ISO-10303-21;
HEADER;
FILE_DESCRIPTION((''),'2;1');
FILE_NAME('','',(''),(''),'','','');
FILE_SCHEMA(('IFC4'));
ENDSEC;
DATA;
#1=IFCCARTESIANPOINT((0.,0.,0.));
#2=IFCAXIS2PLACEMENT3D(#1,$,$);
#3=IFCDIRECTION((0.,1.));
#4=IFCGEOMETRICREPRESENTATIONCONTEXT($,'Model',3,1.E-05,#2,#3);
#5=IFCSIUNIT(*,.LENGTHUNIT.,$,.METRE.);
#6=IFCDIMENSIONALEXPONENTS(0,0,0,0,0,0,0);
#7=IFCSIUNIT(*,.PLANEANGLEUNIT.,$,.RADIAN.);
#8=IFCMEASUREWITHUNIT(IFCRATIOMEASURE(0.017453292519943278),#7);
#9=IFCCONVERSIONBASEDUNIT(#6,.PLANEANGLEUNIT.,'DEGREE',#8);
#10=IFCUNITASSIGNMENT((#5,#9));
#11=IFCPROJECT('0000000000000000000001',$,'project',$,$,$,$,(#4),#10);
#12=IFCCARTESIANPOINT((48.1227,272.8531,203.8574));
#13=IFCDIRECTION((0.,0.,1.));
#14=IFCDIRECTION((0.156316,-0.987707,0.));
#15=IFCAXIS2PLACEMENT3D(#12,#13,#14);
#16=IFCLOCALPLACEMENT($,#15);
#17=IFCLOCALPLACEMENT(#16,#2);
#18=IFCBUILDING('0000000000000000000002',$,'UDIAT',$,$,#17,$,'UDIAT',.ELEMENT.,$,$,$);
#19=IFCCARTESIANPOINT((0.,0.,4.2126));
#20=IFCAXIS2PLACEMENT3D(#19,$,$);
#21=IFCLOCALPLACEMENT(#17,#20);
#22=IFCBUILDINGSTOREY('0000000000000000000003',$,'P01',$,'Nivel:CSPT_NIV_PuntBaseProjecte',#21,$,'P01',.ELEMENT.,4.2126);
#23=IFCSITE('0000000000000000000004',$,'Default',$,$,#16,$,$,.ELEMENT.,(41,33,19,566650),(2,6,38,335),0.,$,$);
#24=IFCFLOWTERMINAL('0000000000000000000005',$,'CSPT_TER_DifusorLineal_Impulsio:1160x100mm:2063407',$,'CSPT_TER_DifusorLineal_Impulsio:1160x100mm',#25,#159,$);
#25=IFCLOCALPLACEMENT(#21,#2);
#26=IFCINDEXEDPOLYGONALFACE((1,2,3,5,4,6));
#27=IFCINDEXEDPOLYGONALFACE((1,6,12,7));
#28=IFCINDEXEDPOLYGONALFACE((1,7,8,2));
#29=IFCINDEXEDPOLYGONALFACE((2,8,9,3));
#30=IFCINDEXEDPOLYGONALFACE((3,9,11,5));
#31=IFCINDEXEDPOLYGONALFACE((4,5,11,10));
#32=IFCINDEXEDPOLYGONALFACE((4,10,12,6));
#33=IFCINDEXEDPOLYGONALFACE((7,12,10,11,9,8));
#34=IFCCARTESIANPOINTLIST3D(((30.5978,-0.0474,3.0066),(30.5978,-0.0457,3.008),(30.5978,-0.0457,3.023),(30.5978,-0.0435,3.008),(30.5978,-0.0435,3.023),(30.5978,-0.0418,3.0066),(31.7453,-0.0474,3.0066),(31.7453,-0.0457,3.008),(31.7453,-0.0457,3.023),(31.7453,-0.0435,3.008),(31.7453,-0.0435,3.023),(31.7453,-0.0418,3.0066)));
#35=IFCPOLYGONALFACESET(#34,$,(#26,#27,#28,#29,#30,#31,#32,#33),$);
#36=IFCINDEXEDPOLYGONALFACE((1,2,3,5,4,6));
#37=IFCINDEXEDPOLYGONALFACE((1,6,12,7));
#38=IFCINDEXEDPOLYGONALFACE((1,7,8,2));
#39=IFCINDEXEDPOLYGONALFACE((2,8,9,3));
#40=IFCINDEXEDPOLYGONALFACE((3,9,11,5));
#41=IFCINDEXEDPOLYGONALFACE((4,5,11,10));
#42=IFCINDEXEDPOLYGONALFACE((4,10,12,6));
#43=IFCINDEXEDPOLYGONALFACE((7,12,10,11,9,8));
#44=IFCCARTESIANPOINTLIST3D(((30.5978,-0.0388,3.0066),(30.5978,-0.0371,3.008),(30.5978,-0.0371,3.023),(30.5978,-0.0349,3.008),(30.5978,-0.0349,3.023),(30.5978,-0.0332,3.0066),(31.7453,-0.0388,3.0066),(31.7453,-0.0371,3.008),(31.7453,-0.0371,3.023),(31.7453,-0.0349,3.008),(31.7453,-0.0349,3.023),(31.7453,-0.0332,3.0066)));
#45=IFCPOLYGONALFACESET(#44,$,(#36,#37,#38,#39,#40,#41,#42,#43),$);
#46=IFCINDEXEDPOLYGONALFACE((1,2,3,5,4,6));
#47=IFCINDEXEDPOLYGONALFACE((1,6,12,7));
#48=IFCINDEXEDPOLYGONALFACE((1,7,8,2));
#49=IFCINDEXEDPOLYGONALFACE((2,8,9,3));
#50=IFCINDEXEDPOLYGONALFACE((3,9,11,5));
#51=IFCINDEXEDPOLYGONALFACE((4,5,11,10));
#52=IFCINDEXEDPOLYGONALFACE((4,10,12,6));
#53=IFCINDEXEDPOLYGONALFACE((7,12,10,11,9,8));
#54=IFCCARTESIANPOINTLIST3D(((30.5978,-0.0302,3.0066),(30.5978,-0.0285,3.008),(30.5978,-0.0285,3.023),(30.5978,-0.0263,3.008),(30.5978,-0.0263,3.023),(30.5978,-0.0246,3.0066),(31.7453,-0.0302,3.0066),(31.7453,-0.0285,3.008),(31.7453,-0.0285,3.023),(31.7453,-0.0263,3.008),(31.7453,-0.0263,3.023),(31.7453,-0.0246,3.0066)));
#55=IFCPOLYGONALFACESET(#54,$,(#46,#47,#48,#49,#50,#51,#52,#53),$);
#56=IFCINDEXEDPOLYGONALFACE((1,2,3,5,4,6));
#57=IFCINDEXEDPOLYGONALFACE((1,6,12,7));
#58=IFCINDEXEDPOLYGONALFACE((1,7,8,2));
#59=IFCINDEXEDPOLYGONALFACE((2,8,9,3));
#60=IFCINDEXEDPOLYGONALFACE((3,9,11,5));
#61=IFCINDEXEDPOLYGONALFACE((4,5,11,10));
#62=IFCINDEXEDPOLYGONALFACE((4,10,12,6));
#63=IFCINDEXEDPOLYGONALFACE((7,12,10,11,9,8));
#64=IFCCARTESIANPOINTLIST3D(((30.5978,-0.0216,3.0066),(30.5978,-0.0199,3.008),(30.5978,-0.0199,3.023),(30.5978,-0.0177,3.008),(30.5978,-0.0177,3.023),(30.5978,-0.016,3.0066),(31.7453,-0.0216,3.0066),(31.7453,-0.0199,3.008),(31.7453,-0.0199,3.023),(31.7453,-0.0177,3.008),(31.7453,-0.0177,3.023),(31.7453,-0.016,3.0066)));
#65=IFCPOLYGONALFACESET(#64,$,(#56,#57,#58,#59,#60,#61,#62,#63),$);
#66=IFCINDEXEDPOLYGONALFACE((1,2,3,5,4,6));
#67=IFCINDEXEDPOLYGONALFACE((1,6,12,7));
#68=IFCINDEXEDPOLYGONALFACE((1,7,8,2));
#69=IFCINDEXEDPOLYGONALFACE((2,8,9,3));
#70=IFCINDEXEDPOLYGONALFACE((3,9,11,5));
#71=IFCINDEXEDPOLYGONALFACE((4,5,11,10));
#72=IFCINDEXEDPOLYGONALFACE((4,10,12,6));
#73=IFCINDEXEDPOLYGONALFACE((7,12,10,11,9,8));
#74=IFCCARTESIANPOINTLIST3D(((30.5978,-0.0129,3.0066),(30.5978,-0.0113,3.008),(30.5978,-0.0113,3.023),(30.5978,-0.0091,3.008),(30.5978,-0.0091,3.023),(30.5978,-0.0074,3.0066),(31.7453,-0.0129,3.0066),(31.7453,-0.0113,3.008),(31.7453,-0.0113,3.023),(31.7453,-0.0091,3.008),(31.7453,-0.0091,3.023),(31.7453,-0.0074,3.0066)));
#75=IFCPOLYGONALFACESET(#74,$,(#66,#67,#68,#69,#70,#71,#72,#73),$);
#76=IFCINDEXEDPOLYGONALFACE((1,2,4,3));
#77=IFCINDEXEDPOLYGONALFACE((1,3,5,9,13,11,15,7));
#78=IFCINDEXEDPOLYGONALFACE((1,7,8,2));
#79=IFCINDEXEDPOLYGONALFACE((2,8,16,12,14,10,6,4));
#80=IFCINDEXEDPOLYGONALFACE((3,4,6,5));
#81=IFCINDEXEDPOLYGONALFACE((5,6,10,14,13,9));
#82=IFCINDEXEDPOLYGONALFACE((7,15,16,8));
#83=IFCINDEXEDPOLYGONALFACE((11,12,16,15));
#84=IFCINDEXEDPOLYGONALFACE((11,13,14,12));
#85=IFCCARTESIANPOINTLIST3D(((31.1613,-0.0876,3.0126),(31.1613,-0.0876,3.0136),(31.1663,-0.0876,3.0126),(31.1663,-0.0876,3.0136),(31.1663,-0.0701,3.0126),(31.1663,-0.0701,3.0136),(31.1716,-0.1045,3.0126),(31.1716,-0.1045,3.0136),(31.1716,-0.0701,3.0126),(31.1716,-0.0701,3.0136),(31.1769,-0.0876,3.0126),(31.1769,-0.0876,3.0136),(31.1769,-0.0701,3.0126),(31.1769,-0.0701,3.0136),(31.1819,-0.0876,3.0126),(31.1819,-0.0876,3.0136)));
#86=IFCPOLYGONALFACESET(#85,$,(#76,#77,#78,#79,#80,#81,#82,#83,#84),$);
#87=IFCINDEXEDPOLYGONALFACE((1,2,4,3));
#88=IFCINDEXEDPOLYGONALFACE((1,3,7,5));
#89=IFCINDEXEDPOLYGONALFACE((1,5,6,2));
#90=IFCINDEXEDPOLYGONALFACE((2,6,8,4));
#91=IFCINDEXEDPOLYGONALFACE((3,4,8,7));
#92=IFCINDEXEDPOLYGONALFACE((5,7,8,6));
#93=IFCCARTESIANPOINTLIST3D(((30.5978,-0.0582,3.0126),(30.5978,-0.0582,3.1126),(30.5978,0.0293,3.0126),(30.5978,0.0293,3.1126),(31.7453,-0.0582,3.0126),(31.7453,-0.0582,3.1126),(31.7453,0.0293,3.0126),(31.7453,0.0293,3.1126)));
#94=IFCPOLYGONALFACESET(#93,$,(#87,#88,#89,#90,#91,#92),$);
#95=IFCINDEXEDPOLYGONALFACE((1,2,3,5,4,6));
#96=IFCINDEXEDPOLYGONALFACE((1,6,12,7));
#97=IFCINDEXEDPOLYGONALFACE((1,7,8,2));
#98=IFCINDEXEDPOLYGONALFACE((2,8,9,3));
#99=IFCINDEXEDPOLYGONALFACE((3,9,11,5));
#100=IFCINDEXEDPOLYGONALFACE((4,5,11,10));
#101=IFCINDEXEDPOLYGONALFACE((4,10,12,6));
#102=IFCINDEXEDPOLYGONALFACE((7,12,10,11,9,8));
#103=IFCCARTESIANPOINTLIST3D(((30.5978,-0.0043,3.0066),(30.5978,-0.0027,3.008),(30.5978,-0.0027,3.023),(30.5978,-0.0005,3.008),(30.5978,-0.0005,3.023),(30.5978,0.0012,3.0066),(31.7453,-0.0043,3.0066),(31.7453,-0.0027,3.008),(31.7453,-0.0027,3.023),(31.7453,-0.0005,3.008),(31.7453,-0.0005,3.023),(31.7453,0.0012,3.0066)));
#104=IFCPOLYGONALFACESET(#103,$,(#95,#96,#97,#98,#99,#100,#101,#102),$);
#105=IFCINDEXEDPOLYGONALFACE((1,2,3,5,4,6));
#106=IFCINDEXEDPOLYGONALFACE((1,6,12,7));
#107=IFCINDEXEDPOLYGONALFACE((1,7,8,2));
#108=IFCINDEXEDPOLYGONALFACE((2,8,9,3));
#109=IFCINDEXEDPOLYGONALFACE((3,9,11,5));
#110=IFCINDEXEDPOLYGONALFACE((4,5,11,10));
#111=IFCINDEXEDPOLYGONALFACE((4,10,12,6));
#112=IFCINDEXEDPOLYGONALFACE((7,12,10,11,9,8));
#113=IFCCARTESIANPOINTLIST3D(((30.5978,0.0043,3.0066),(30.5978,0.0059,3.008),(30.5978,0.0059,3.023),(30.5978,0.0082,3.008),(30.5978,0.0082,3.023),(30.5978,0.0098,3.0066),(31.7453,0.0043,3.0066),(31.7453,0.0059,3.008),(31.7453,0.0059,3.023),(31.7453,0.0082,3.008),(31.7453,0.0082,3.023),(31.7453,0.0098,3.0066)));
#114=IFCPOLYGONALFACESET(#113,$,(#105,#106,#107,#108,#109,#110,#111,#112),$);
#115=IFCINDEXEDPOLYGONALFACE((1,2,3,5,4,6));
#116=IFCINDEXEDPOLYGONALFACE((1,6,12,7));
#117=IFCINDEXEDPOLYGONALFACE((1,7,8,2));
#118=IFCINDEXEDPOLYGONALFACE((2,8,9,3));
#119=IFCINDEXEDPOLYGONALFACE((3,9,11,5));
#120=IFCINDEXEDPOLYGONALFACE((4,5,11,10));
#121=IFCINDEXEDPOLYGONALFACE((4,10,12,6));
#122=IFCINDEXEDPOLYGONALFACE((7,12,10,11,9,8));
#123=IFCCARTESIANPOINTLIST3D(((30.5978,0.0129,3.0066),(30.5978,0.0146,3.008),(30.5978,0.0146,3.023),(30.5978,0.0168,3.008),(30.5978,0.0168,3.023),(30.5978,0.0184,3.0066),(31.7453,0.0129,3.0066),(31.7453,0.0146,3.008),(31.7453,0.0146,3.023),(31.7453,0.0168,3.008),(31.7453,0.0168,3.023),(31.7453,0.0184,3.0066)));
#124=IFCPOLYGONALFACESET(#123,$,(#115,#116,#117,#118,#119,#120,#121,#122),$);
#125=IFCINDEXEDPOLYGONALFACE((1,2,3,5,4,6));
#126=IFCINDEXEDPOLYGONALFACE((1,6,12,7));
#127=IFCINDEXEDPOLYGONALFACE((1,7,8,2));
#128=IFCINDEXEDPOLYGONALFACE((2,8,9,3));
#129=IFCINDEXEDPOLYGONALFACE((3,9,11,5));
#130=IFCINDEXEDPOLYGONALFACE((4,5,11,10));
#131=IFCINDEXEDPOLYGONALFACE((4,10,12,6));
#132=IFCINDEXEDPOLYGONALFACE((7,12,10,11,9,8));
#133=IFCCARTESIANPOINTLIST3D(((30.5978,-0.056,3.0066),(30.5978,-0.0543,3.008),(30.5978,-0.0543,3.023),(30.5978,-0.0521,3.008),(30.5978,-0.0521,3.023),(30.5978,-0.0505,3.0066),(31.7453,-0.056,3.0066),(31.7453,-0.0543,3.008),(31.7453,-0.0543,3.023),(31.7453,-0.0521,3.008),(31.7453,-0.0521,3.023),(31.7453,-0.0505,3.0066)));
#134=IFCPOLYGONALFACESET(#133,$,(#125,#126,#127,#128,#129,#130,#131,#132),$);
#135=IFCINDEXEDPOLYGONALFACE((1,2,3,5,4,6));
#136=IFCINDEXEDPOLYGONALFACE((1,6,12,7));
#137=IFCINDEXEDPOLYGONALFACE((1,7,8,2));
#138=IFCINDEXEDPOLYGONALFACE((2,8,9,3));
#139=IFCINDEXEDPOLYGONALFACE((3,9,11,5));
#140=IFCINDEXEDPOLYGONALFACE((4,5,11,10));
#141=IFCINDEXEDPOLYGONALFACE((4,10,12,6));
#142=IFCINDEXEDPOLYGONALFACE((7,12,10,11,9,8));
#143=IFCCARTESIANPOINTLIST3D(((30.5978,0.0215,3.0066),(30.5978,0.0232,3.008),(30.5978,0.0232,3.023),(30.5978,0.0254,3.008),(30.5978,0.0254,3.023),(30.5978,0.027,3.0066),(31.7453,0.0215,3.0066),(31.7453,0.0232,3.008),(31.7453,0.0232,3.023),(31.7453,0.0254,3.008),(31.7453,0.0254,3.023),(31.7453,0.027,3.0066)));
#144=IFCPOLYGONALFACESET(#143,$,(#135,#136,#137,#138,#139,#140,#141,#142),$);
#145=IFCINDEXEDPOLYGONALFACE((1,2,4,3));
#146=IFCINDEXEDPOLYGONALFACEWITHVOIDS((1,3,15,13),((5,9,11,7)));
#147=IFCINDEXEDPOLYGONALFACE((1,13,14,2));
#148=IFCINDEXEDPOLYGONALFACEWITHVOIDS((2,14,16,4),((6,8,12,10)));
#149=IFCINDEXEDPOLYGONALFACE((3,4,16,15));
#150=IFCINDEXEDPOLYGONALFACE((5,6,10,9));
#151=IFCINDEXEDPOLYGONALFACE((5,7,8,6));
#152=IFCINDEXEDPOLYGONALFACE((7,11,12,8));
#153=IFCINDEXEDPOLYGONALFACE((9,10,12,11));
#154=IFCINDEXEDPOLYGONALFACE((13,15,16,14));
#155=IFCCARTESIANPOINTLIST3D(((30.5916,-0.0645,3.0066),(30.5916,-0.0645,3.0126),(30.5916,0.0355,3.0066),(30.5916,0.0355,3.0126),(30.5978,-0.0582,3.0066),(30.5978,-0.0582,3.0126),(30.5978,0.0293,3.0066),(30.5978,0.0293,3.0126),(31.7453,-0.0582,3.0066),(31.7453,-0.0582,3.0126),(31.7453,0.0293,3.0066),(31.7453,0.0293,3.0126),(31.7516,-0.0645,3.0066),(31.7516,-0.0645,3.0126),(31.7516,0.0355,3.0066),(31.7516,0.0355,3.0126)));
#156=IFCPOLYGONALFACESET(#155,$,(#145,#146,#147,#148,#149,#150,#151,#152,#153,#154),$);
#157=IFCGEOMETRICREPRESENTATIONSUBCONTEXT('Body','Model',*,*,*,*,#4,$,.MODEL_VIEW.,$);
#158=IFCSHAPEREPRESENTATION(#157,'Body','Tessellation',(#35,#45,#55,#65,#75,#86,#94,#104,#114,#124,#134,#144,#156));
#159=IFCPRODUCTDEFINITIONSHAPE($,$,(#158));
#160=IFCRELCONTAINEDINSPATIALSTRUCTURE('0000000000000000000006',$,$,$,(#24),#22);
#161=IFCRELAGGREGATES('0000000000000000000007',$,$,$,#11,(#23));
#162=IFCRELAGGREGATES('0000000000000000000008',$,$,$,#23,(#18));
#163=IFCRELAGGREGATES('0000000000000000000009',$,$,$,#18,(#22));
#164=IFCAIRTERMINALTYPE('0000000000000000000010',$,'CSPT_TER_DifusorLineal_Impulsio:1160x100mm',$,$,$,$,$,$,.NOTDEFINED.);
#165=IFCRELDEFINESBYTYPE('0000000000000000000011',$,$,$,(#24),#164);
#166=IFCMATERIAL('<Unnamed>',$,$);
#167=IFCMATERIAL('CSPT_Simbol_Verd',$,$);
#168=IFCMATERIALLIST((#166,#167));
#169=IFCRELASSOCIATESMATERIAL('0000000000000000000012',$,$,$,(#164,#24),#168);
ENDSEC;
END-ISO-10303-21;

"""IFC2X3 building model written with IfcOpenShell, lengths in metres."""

from ifc_helpers import new_model, entity, si_unit, converted_unit, direction, frame, origin, origin_2d_with_axis, place, context, subcontext, project, spatial, polyline, rectangle, outline, extrude, source, transform, mapped, material, material_list, type_object, type_shapes, element, save


model = new_model("IFC2X3")

# Units and contexts
model_context = context("Model", 3, precision=1e-05, world=origin(), true_north=direction((0.0, 1.0)))
body_context = subcontext(model_context, "Body", "Model", "MODEL_VIEW")
ifc_project = project(units=[si_unit("LENGTHUNIT", "METRE"), converted_unit("PLANEANGLEUNIT", "DEGREE", entity("IfcRatioMeasure", 0.017453292519943278), si_unit("PLANEANGLEUNIT", "RADIAN"), dimensions=[0, 0, 0, 0, 0, 0, 0])], contexts=[model_context])

# Site, building, storey
site_placement = place(None, frame((48.1227, 272.8531, 203.8574), z_axis=(0.0, 0.0, 1.0), x_axis=(0.156316, -0.987707, 0.0)))
site = spatial("IfcSite", under=ifc_project, at=site_placement, Name="Default", CompositionType="ELEMENT", RefLatitude=(41, 33, 19, 566650), RefLongitude=(2, 6, 38, 335), RefElevation=0.0)
building_placement = place(site_placement, origin())
building = spatial("IfcBuilding", under=site, at=building_placement, Name="UDIAT", LongName="UDIAT", CompositionType="ELEMENT")
storey_placement = place(building_placement, frame((0.0, 0.0, 4.2126)))
storey = spatial("IfcBuildingStorey", under=building, at=storey_placement, Name="P01", ObjectType="Nivel:CSPT_NIV_PuntBaseProjecte", LongName="P01", CompositionType="ELEMENT", Elevation=4.2126)

# Shared definitions
ifc_material_1 = material(Name="<Unnamed>")

# Flow terminal
ifc_material_2 = material(Name="CSPT_Simbol_Verd")
ifc_material_list = material_list([ifc_material_1, ifc_material_2])
air_terminal_type = type_object("IfcAirTerminalType", Name="CSPT_TER_DifusorLineal_Impulsio:1160x100mm", PredefinedType="NOTDEFINED", material=ifc_material_list)
shared_shape_1 = source(origin(), body_context, "Body", "SweptSolid", [
    extrude(outline(polyline([(0.0037, 0.0028), (0.0059, 0.0028), (0.0016, 0.0063), (0.002, 0.0042), (-0.0074, -0.0074), (-0.0057, -0.0088), (0.0037, 0.0028)])), frame((-0.5737, 0.0301, -0.0001), z_axis=(1.0, 0.0, 0.0), x_axis=(0.0, -0.776119, -0.630587)), (0.0, 0.0, 1.0), 1.1475),
    extrude(outline(polyline([(0.0037, 0.0028), (0.0059, 0.0028), (0.0016, 0.0063), (0.002, 0.0042), (-0.0074, -0.0074), (-0.0057, -0.0088), (0.0037, 0.0028)])), frame((-0.5737, 0.0215, -0.0001), z_axis=(1.0, 0.0, 0.0), x_axis=(0.0, -0.776119, -0.630587)), (0.0, 0.0, 1.0), 1.1475),
    extrude(outline(polyline([(0.0037, 0.0028), (0.0059, 0.0028), (0.0016, 0.0063), (0.002, 0.0042), (-0.0074, -0.0074), (-0.0057, -0.0088), (0.0037, 0.0028)])), frame((-0.5737, 0.0129, -0.0001), z_axis=(1.0, 0.0, 0.0), x_axis=(0.0, -0.776119, -0.630587)), (0.0, 0.0, 1.0), 1.1475),
    extrude(outline(polyline([(0.0037, 0.0028), (0.0059, 0.0028), (0.0016, 0.0063), (0.002, 0.0042), (-0.0074, -0.0074), (-0.0057, -0.0088), (0.0037, 0.0028)])), frame((-0.5737, 0.0043, -0.0001), z_axis=(1.0, 0.0, 0.0), x_axis=(0.0, -0.776119, -0.630587)), (0.0, 0.0, 1.0), 1.1475),
    extrude(outline(polyline([(0.0037, 0.0028), (0.0059, 0.0028), (0.0016, 0.0063), (0.002, 0.0042), (-0.0074, -0.0074), (-0.0057, -0.0088), (0.0037, 0.0028)])), frame((-0.5737, -0.0043, -0.0001), z_axis=(1.0, 0.0, 0.0), x_axis=(0.0, -0.776119, -0.630587)), (0.0, 0.0, 1.0), 1.1475),
    extrude(outline(polyline([(0.0, -0.013), (0.0053, -0.013), (0.0053, 0.0045), (0.0103, 0.0045), (0.0, 0.0213), (-0.0103, 0.0045), (-0.0053, 0.0045), (-0.0053, -0.013), (0.0, -0.013)])), frame((0.0, 0.0687, 0.0)), (0.0, 0.0, 1.0), 0.001),
    extrude(rectangle(XDim=1.1475, YDim=0.0875, at=origin_2d_with_axis()), frame((0.0, 0.0, 0.0), z_axis=(0.0, 0.0, 1.0), x_axis=(-1.0, 0.0, 0.0)), (0.0, 0.0, 1.0), 0.1),
    extrude(outline(polyline([(0.0037, 0.0028), (0.0059, 0.0028), (0.0016, 0.0063), (0.002, 0.0042), (-0.0074, -0.0074), (-0.0057, -0.0088), (0.0037, 0.0028)])), frame((-0.5737, -0.0129, -0.0001), z_axis=(1.0, 0.0, 0.0), x_axis=(0.0, -0.776119, -0.630587)), (0.0, 0.0, 1.0), 1.1475),
    extrude(outline(polyline([(0.0037, 0.0028), (0.0059, 0.0028), (0.0016, 0.0063), (0.002, 0.0042), (-0.0074, -0.0074), (-0.0057, -0.0088), (0.0037, 0.0028)])), frame((-0.5737, -0.0215, -0.0001), z_axis=(1.0, 0.0, 0.0), x_axis=(0.0, -0.776119, -0.630587)), (0.0, 0.0, 1.0), 1.1475),
    extrude(outline(polyline([(0.0037, 0.0028), (0.0059, 0.0028), (0.0016, 0.0063), (0.002, 0.0042), (-0.0074, -0.0074), (-0.0057, -0.0088), (0.0037, 0.0028)])), frame((-0.5737, -0.0301, -0.0001), z_axis=(1.0, 0.0, 0.0), x_axis=(0.0, -0.776119, -0.630587)), (0.0, 0.0, 1.0), 1.1475),
    extrude(outline(polyline([(0.0037, 0.0028), (0.0059, 0.0028), (0.0016, 0.0063), (0.002, 0.0042), (-0.0074, -0.0074), (-0.0057, -0.0088), (0.0037, 0.0028)])), frame((-0.5737, 0.0388, -0.0001), z_axis=(1.0, 0.0, 0.0), x_axis=(0.0, -0.776119, -0.630587)), (0.0, 0.0, 1.0), 1.1475),
    extrude(outline(polyline([(0.0037, 0.0028), (0.0059, 0.0028), (0.0016, 0.0063), (0.002, 0.0042), (-0.0074, -0.0074), (-0.0057, -0.0088), (0.0037, 0.0028)])), frame((-0.5737, -0.0387, -0.0001), z_axis=(1.0, 0.0, 0.0), x_axis=(0.0, -0.776119, -0.630587)), (0.0, 0.0, 1.0), 1.1475),
    extrude(outline(polyline([(-0.58, -0.05), (0.58, -0.05), (0.58, 0.05), (-0.58, 0.05), (-0.58, -0.05)]), holes=[polyline([(-0.5738, -0.0438), (-0.5738, 0.0437), (0.5737, 0.0437), (0.5737, -0.0438), (-0.5738, -0.0438)])]), frame((0.0, 0.0, -0.006), z_axis=(0.0, 0.0, 1.0), x_axis=(-1.0, 0.0, 0.0)), (0.0, 0.0, 1.0), 0.006),
])
type_shapes(air_terminal_type, [shared_shape_1])
for number, where, z_axis, x_axis, name in (
    (1, (31.1716, -0.0145, 3.0126), (0.0, 0.0, 1.0), (-1.0, 0.0, 0.0), "CSPT_TER_DifusorLineal_Impulsio:1160x100mm:2063407"),
):
    element("IfcFlowTerminal", number, at=place(storey_placement, frame(where, z_axis=z_axis, x_axis=x_axis)), inside=storey, type_object=air_terminal_type, material=ifc_material_list, Name=name, ObjectType="CSPT_TER_DifusorLineal_Impulsio:1160x100mm", context=body_context, shape_type="MappedRepresentation", body=[
        mapped(shared_shape_1, transform((0.0, 0.0, 0.0), scale=1.0)),
    ])

save(model, "model.ifc")
